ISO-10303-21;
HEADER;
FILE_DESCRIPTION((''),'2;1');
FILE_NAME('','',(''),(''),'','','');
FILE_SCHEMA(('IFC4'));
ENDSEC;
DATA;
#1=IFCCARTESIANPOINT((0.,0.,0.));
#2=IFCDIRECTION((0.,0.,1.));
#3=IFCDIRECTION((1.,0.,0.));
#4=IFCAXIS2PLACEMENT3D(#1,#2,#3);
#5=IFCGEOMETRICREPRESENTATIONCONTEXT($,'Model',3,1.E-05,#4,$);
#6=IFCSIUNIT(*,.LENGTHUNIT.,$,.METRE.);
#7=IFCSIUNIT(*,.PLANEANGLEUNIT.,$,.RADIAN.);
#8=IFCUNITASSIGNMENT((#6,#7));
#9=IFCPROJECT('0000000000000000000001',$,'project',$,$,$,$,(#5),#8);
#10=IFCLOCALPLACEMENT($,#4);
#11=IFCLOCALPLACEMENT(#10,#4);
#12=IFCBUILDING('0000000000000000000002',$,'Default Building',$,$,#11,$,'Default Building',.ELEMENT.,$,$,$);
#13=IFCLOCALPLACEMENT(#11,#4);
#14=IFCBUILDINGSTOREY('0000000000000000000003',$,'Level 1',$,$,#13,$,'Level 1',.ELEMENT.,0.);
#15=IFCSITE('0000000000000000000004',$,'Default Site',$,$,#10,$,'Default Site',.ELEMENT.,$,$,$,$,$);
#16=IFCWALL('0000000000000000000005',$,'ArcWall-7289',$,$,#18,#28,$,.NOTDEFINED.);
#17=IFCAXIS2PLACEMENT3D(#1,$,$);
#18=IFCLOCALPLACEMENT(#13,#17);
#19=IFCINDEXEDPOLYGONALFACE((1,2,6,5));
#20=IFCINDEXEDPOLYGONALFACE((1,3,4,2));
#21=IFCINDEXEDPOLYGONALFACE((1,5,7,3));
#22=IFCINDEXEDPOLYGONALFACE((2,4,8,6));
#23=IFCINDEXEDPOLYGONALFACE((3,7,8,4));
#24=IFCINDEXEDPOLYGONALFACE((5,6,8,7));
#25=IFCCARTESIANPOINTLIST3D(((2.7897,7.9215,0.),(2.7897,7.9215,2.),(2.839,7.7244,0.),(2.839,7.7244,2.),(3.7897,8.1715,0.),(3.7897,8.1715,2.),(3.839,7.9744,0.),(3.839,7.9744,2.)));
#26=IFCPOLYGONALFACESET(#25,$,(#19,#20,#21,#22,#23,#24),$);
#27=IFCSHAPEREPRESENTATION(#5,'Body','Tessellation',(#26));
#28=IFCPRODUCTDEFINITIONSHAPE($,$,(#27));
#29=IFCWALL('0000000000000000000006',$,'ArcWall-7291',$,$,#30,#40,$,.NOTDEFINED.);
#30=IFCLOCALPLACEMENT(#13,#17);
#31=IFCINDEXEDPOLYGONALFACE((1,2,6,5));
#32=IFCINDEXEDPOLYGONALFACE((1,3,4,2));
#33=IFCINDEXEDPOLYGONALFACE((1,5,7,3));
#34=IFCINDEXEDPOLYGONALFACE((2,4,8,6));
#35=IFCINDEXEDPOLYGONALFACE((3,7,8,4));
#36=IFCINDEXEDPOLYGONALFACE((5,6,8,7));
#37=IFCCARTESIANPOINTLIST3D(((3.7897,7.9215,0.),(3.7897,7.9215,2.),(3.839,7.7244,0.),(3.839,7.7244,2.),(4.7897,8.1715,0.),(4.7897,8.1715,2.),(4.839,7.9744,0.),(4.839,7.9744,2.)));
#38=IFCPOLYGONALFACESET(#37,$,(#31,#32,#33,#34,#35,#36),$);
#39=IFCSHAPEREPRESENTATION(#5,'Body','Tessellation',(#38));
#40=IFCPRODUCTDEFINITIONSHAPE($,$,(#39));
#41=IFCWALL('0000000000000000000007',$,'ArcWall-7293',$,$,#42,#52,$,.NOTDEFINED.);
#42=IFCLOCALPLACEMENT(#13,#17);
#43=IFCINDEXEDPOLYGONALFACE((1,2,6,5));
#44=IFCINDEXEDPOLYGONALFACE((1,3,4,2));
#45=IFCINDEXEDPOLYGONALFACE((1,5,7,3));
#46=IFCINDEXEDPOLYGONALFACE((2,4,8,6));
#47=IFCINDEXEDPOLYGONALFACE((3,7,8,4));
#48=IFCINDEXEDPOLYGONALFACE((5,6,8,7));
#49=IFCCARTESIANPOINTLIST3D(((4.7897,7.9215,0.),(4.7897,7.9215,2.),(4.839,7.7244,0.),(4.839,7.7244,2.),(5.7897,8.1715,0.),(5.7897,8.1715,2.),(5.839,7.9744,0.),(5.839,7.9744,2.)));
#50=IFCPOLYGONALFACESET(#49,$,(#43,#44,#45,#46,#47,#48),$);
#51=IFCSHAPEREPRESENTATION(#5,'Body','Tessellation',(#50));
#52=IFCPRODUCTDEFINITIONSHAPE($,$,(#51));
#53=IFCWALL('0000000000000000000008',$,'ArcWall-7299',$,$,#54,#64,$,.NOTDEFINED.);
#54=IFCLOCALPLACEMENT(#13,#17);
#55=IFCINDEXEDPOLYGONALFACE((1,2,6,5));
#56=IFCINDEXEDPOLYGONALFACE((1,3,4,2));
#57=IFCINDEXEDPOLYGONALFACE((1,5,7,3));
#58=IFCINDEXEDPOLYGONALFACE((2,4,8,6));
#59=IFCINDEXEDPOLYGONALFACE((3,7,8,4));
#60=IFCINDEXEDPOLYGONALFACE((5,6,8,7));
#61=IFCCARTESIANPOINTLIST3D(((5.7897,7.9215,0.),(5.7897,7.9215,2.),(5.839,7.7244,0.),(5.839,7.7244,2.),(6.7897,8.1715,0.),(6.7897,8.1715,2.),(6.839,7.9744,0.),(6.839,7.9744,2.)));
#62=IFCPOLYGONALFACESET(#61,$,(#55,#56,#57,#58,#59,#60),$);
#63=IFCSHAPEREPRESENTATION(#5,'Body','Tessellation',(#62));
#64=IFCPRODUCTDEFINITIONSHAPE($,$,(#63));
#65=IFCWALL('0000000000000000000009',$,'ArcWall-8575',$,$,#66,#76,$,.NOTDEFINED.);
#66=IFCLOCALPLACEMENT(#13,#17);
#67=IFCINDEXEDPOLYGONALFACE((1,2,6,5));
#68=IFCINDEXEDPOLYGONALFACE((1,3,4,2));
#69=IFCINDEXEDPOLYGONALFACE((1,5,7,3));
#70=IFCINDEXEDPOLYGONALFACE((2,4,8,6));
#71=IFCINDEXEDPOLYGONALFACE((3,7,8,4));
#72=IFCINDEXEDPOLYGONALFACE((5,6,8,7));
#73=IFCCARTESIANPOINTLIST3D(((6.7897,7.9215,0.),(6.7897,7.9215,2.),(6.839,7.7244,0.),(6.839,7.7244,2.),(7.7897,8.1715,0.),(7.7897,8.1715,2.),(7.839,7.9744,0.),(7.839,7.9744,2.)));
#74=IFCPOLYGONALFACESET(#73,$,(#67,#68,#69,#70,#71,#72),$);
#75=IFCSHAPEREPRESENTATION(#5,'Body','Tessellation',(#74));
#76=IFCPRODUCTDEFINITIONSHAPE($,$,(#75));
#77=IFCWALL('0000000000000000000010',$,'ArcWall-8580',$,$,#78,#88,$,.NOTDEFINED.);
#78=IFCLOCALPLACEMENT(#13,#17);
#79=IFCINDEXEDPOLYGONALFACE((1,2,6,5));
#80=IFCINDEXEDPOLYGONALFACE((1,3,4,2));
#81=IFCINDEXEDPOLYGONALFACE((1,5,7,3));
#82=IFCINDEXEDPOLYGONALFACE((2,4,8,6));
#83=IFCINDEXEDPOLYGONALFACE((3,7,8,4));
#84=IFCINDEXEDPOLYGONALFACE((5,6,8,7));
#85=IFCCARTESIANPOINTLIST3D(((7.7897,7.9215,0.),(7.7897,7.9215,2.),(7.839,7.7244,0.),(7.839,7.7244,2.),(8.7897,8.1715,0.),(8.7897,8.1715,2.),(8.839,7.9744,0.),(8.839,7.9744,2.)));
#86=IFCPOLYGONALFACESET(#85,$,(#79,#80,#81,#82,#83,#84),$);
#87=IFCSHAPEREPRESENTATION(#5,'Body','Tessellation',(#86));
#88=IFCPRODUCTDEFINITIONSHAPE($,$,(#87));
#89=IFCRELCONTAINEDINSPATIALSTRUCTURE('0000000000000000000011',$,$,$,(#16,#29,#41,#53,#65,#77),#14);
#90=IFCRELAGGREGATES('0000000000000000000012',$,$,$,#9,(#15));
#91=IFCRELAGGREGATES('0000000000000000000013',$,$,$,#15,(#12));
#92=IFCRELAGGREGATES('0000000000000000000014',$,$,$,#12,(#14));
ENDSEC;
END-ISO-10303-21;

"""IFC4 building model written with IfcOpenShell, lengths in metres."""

from ifc_helpers import new_model, si_unit, frame, origin_with_axes, origin_2d_with_axis, place, context, project, spatial, rectangle, extrude, element, save


model = new_model("IFC4")

# Units and contexts
model_context = context("Model", 3, precision=1e-05, world=origin_with_axes())
ifc_project = project(units=[si_unit("LENGTHUNIT", "METRE"), si_unit("PLANEANGLEUNIT", "RADIAN")], contexts=[model_context])

# Site, building, storey
site_placement = place(None, origin_with_axes())
site = spatial("IfcSite", under=ifc_project, at=site_placement, Name="Default Site", LongName="Default Site", CompositionType="ELEMENT")
building_placement = place(site_placement, origin_with_axes())
building = spatial("IfcBuilding", under=site, at=building_placement, Name="Default Building", LongName="Default Building", CompositionType="ELEMENT")
storey_placement = place(building_placement, origin_with_axes())
storey = spatial("IfcBuildingStorey", under=building, at=storey_placement, Name="Level 1", LongName="Level 1", CompositionType="ELEMENT", Elevation=0.0)

# Walls
for number, where, z_axis, x_axis, name in (
    (1, (3.3144, 7.948, 0.0), (0.0, 0.0, 1.0), (0.970143, 0.242536, 0.0), "ArcWall-7289"),
    (2, (4.3144, 7.948, 0.0), (0.0, 0.0, 1.0), (0.970143, 0.242536, 0.0), "ArcWall-7291"),
    (3, (5.3144, 7.948, 0.0), (0.0, 0.0, 1.0), (0.970143, 0.242536, 0.0), "ArcWall-7293"),
    (4, (6.3144, 7.948, 0.0), (0.0, 0.0, 1.0), (0.970143, 0.242536, 0.0), "ArcWall-7299"),
    (5, (7.3144, 7.948, 0.0), (0.0, 0.0, 1.0), (0.970143, 0.242536, 0.0), "ArcWall-8575"),
    (6, (8.3144, 7.948, 0.0), (0.0, 0.0, 1.0), (0.970143, 0.242536, 0.0), "ArcWall-8580"),
):
    element("IfcWall", number, at=place(storey_placement, frame(where, z_axis=z_axis, x_axis=x_axis)), inside=storey, Name=name, PredefinedType="NOTDEFINED", context=model_context, shape_type="SweptSolid", body=[
        extrude(rectangle(XDim=1.0308, YDim=0.2032, at=origin_2d_with_axis()), origin_with_axes(), (0.0, 0.0, 1.0), 2.0),
    ])

save(model, "model.ifc")
